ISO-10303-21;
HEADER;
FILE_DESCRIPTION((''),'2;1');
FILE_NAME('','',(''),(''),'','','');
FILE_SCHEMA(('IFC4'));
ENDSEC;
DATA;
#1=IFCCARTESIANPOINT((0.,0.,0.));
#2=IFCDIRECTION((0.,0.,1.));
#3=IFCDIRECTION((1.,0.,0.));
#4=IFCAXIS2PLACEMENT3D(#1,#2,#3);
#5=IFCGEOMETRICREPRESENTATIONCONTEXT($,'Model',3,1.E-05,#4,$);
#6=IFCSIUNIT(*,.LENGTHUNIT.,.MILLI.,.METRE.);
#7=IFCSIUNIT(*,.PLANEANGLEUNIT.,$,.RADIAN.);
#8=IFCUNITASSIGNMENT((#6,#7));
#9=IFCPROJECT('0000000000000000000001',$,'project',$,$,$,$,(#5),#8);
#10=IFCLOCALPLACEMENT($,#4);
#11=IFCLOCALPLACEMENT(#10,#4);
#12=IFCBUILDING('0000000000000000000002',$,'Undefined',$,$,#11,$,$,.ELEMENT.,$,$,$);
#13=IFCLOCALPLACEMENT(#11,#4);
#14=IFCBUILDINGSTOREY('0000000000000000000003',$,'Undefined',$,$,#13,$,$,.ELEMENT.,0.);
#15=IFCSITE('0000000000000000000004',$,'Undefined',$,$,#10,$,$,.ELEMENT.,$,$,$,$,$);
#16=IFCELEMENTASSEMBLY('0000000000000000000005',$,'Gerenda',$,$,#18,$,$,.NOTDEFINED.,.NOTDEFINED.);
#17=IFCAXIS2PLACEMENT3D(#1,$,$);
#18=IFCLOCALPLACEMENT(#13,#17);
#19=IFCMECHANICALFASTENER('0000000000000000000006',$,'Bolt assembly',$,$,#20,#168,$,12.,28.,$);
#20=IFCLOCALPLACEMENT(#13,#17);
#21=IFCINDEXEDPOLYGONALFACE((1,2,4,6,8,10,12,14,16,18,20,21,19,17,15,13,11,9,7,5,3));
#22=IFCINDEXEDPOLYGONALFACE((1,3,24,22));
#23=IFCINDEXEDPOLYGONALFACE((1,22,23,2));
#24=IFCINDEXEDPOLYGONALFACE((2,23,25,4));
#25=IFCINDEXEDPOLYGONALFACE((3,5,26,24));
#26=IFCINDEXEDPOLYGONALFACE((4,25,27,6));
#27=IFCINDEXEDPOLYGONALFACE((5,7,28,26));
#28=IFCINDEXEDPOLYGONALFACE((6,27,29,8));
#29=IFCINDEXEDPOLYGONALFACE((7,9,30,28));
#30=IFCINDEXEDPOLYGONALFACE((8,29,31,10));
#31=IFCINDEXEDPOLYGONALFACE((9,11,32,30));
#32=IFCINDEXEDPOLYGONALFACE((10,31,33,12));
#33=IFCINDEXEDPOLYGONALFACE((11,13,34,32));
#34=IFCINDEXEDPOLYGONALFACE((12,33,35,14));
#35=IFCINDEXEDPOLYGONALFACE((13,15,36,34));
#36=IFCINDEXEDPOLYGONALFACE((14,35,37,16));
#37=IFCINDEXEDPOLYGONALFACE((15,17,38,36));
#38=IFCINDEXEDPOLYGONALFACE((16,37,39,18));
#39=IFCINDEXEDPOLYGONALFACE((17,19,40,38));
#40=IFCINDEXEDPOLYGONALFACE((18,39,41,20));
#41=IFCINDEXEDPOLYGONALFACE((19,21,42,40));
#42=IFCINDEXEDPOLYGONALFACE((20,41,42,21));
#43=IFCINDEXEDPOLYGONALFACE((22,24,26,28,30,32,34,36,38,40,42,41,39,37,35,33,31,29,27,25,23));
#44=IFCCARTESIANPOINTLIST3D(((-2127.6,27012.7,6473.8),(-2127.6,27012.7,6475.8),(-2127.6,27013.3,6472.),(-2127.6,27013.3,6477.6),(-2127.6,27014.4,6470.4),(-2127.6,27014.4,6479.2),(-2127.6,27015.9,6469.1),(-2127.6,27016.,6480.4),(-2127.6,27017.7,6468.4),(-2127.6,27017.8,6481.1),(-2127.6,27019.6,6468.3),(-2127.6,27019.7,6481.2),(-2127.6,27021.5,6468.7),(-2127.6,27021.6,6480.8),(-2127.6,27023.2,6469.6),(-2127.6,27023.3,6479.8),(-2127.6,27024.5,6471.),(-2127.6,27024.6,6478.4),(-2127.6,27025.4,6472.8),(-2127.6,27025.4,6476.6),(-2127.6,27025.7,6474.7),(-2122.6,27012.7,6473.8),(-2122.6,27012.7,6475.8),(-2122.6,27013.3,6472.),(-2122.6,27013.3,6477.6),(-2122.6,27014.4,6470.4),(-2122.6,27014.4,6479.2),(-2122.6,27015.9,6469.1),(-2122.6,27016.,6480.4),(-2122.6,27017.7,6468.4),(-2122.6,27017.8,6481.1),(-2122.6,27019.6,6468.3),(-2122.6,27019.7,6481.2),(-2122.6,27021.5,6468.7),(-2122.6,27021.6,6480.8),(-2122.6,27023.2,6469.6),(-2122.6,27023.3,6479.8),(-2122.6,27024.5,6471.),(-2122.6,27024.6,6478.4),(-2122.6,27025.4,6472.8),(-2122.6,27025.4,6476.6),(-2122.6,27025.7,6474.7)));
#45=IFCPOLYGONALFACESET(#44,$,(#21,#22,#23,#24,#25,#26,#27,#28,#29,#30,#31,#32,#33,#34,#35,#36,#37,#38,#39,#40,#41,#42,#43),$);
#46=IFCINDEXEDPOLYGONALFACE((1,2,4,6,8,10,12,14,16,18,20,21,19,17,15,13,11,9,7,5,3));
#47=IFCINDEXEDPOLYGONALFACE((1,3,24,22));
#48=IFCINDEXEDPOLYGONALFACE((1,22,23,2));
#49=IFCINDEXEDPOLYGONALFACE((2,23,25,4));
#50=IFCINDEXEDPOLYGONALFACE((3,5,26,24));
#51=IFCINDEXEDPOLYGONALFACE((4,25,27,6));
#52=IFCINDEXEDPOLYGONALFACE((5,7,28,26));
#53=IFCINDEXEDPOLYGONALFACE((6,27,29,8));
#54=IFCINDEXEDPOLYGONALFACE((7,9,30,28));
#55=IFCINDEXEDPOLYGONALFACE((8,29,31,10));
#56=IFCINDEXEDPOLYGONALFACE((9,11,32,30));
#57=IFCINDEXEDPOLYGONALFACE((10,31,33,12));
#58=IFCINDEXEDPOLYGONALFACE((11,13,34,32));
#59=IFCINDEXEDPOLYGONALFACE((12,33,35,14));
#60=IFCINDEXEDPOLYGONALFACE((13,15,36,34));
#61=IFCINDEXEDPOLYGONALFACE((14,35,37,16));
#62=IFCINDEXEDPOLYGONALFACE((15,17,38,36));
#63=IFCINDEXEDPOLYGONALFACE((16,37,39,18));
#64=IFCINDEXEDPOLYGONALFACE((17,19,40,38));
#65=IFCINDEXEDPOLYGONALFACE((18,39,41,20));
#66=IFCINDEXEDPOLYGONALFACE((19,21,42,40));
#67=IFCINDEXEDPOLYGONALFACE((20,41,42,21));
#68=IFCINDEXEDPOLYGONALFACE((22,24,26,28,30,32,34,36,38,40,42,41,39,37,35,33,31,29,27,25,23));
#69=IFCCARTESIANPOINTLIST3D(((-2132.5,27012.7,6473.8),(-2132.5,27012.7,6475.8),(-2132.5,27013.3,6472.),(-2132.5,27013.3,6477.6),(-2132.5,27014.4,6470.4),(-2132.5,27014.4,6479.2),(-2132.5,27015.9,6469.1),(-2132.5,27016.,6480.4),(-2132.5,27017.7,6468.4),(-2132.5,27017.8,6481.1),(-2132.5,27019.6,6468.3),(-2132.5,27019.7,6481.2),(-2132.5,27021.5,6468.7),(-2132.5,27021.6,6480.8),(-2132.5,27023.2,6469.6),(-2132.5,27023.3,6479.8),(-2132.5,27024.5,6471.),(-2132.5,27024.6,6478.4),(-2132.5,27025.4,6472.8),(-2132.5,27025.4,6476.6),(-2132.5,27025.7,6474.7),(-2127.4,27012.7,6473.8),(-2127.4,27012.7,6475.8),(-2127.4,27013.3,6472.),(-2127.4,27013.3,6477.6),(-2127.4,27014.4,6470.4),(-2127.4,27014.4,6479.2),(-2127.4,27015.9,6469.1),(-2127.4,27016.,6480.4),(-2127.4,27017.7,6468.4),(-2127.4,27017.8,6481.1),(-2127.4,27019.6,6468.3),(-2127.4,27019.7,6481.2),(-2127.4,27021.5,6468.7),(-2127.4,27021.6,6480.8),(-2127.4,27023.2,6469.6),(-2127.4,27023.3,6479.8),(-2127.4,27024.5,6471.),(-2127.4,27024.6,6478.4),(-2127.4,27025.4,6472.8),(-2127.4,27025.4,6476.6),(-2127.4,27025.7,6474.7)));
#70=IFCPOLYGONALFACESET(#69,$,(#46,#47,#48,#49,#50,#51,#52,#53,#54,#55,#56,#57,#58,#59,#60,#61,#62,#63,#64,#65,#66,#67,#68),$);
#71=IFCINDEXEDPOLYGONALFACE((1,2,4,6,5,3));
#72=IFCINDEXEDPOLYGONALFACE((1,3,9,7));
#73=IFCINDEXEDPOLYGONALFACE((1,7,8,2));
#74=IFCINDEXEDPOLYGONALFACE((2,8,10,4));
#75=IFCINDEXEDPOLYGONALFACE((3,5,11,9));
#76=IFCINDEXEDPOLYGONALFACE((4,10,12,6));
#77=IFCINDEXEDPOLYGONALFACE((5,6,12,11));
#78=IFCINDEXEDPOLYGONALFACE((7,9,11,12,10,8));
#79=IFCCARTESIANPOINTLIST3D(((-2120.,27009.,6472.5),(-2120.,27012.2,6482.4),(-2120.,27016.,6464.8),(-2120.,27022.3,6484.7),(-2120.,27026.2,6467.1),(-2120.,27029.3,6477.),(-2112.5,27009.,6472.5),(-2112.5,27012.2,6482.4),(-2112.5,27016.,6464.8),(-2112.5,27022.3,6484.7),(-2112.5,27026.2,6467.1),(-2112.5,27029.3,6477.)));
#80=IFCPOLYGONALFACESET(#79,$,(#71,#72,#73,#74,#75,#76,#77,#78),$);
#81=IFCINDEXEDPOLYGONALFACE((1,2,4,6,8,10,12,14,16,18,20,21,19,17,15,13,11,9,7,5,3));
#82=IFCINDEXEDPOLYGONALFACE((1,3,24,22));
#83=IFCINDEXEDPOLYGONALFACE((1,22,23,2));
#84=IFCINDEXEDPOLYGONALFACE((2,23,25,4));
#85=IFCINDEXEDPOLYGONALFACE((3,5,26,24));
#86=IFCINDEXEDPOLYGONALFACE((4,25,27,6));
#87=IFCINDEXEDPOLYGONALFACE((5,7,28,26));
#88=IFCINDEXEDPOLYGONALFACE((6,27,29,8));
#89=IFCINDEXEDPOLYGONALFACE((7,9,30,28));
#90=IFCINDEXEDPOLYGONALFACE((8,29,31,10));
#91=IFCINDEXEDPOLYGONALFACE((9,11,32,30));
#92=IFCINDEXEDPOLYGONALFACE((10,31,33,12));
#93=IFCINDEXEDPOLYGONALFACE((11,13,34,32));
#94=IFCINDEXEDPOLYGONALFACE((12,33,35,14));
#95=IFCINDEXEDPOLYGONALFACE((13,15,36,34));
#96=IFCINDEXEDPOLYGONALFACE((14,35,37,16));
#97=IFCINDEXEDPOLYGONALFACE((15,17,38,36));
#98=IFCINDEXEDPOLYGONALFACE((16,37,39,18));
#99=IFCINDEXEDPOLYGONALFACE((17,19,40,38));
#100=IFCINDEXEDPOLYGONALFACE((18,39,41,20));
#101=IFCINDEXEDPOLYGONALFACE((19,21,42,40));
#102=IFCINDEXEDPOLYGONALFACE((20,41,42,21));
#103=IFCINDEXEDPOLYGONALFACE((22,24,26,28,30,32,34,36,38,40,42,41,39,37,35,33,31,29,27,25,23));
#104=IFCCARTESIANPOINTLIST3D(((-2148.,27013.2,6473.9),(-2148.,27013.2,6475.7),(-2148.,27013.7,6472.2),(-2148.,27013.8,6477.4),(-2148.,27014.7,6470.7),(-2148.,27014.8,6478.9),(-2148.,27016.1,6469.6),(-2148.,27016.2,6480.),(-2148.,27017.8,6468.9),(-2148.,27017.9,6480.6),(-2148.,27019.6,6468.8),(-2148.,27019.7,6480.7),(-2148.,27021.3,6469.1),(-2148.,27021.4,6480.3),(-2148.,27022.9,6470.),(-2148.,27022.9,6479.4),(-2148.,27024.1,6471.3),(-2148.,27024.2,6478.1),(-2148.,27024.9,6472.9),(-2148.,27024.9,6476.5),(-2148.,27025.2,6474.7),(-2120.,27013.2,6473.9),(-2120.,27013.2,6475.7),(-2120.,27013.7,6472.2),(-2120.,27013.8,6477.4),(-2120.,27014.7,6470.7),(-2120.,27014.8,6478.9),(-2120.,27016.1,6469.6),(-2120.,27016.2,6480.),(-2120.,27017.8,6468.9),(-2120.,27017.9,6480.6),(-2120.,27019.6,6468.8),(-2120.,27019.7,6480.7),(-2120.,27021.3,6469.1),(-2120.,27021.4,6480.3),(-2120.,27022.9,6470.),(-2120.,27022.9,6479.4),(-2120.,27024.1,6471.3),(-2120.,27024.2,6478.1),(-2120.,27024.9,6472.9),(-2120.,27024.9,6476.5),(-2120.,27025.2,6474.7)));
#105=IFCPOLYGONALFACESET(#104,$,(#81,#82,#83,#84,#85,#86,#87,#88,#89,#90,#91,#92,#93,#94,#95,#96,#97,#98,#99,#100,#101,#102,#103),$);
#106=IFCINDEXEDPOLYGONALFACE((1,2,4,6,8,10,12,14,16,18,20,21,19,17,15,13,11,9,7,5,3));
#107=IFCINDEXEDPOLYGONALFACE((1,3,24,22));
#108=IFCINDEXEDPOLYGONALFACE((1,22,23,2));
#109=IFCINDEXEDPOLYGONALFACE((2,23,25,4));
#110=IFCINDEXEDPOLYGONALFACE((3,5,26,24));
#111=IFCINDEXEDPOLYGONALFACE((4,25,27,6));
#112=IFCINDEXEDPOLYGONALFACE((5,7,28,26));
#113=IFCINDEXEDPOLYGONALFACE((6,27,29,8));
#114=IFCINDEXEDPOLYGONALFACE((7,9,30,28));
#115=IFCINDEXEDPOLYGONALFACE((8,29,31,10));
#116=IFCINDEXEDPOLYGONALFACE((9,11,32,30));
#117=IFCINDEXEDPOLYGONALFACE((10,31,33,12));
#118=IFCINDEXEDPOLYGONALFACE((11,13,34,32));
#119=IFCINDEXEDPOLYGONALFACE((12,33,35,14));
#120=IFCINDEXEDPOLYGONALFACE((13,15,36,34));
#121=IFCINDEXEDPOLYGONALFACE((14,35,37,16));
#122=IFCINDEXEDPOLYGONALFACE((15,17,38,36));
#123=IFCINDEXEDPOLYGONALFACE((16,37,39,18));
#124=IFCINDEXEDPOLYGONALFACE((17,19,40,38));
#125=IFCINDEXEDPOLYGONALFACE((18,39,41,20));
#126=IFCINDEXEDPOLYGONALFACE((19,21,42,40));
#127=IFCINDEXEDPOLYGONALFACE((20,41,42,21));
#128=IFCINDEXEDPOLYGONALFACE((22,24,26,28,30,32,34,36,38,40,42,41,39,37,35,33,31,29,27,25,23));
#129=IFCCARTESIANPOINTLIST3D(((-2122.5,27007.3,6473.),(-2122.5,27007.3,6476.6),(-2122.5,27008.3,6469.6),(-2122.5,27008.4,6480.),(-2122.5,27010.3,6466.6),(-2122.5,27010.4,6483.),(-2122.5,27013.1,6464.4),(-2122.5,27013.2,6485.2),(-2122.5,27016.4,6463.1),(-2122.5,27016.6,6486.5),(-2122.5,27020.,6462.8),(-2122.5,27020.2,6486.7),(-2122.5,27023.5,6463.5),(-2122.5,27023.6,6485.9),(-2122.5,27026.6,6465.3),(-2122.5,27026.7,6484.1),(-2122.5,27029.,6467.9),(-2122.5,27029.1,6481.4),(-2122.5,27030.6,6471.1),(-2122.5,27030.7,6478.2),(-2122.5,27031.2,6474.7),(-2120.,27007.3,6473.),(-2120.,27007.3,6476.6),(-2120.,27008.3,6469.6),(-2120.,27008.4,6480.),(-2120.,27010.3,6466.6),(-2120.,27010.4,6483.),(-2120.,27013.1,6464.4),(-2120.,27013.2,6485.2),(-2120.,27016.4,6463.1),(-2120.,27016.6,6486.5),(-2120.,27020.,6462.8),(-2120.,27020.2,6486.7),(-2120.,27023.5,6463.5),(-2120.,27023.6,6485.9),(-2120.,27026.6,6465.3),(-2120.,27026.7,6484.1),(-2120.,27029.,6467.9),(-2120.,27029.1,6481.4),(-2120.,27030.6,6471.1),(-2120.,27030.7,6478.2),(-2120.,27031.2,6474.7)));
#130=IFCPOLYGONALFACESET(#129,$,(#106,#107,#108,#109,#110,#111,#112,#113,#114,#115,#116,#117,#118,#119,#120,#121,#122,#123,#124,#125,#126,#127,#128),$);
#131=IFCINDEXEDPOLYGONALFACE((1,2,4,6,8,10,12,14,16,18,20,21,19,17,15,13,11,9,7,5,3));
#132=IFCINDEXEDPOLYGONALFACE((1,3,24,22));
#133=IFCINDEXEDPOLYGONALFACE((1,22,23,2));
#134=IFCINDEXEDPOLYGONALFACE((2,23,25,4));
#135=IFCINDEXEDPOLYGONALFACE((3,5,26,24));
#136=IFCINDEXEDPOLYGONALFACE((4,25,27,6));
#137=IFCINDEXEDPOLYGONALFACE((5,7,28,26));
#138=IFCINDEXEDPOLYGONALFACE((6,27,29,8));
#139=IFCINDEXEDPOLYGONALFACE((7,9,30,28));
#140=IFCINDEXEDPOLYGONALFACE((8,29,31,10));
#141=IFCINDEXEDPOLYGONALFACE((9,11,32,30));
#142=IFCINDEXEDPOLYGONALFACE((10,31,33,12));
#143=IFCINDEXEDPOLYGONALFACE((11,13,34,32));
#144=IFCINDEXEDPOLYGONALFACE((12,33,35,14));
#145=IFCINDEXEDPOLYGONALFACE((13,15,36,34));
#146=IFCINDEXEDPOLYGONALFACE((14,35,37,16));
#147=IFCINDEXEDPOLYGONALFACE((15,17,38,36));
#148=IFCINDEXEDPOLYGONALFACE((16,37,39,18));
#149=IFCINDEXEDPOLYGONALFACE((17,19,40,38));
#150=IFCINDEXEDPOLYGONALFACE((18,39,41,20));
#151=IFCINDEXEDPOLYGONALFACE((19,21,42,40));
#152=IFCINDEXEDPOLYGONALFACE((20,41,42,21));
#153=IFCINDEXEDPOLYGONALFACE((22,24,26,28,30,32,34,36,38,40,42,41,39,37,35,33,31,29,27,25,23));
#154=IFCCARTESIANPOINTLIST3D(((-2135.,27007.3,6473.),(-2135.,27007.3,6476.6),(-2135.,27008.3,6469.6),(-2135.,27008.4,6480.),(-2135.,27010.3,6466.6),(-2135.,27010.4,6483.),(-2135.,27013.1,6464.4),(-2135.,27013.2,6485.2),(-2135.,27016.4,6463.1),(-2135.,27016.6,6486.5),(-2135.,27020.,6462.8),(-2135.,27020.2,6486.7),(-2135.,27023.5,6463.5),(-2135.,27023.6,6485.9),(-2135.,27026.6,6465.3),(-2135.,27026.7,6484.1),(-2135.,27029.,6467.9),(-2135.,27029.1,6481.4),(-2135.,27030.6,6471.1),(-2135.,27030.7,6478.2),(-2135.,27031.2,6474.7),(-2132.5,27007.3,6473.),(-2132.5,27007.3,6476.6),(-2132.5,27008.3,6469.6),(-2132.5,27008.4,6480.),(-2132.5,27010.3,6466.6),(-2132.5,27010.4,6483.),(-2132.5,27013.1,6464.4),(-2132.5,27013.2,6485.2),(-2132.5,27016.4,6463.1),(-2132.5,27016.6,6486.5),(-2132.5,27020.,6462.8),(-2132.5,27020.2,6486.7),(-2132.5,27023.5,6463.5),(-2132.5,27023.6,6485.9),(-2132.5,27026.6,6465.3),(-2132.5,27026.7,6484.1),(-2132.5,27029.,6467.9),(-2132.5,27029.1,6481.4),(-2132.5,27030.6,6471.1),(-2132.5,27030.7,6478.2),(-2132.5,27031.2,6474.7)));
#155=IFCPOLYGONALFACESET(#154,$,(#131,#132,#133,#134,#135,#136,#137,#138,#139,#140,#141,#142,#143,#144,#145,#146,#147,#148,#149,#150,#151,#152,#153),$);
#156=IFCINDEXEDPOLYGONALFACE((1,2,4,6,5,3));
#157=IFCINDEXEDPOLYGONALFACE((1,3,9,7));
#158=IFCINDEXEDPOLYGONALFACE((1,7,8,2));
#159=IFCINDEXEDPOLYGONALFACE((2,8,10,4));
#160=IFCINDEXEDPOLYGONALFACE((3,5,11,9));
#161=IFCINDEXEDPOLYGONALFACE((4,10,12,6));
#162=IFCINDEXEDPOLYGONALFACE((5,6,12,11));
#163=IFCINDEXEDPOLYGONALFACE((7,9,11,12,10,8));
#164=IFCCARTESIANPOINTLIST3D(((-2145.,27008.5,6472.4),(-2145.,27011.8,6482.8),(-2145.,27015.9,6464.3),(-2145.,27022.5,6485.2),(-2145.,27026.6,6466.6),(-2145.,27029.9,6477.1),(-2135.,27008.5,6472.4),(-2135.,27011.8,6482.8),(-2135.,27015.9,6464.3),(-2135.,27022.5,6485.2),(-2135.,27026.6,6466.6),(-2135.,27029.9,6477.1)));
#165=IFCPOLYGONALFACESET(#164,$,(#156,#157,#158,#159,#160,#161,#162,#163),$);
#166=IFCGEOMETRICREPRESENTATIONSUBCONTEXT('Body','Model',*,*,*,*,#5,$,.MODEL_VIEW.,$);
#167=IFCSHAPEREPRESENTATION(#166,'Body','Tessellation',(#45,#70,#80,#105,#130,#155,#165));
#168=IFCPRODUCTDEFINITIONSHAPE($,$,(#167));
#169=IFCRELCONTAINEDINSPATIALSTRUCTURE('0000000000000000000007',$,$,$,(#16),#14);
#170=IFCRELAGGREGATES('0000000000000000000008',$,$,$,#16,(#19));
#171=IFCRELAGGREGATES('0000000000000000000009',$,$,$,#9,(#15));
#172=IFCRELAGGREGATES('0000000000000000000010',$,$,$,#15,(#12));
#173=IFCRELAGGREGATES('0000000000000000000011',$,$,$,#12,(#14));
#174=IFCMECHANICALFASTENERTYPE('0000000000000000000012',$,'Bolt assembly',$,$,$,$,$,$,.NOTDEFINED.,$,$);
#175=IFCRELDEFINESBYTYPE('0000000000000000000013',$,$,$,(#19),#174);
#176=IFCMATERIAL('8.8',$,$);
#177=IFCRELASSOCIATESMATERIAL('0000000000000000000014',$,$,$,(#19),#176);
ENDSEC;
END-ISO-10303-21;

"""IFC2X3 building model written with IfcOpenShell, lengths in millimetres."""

from ifc_helpers import new_model, si_unit, frame, origin_with_axes, origin_2d_with_axis, place, context, subcontext, project, spatial, polyline, circle, outline, extrude, source, transform, mapped, material, type_object, element, aggregate, save


model = new_model("IFC2X3")

# Units and contexts
model_context = context("Model", 3, precision=1e-05, world=origin_with_axes())
body_context = subcontext(model_context, "Body", "Model", "MODEL_VIEW")
ifc_project = project(units=[si_unit("LENGTHUNIT", "METRE", prefix="MILLI"), si_unit("PLANEANGLEUNIT", "RADIAN")], contexts=[model_context])

# Site, building, storey
site_placement = place(None, origin_with_axes())
site = spatial("IfcSite", under=ifc_project, at=site_placement, Name="Undefined", CompositionType="ELEMENT")
building_placement = place(site_placement, origin_with_axes())
building = spatial("IfcBuilding", under=site, at=building_placement, Name="Undefined", CompositionType="ELEMENT")
storey_placement = place(building_placement, origin_with_axes())
storey = spatial("IfcBuildingStorey", under=building, at=storey_placement, Name="Undefined", CompositionType="ELEMENT", Elevation=0.0)

# Element assembly
assembly_1_placement = place(storey_placement, origin_with_axes())
assembly_1 = element("IfcElementAssembly", 1, at=assembly_1_placement, inside=storey, Name="Gerenda", AssemblyPlace="NOTDEFINED", PredefinedType="NOTDEFINED")

# Mechanical fastener
ifc_material_1 = material(Name="8.8")
mechanical_fastener_type = type_object("IfcMechanicalFastenerType", Name="Bolt assembly")
shared_shape_1 = source(origin_with_axes(), body_context, "Body", "SweptSolid", [
    extrude(circle(Radius=6.5, at=origin_2d_with_axis()), frame((0.0, -7.4, 0.0), z_axis=(0.0, 1.0, 0.0), x_axis=(1.0, 0.0, 0.0)), (0.0, 0.0, 1.0), 5.0),
    extrude(circle(Radius=6.5, at=origin_2d_with_axis()), frame((0.0, -2.6, 0.0), z_axis=(0.0, 1.0, 0.0), x_axis=(1.0, 0.0, 0.0)), (0.0, 0.0, 1.0), 5.1),
    extrude(outline(polyline([(9.0, -5.2), (9.0, 5.2), (0.0, 10.4), (-9.0, 5.2), (-9.0, -5.2), (0.0, -10.4), (9.0, -5.2)])), frame((0.0, -17.5, 0.0), z_axis=(0.0, 1.0, 0.0), x_axis=(1.0, 0.0, 0.0)), (0.0, 0.0, 1.0), 7.5),
    extrude(circle(Radius=6.0, at=origin_2d_with_axis()), frame((0.0, -10.0, 0.0), z_axis=(0.0, 1.0, 0.0), x_axis=(1.0, 0.0, 0.0)), (0.0, 0.0, 1.0), 28.0),
    extrude(circle(Radius=12.0, at=origin_2d_with_axis()), frame((0.0, -10.0, 0.0), z_axis=(0.0, 1.0, 0.0), x_axis=(1.0, 0.0, 0.0)), (0.0, 0.0, 1.0), 2.5),
    extrude(circle(Radius=12.0, at=origin_2d_with_axis()), frame((0.0, 2.5, 0.0), z_axis=(0.0, 1.0, 0.0), x_axis=(1.0, 0.0, 0.0)), (0.0, 0.0, 1.0), 2.5),
    extrude(outline(polyline([(9.5, -5.5), (9.5, 5.5), (0.0, 11.0), (-9.5, 5.5), (-9.5, -5.5), (0.0, -11.0), (9.5, -5.5)])), frame((0.0, 5.0, 0.0), z_axis=(0.0, 1.0, 0.0), x_axis=(1.0, 0.0, 0.0)), (0.0, 0.0, 1.0), 10.0),
])
mechanical_fastener_1_placement = place(assembly_1_placement, frame((-2130.0, 27019.2, 6474.7), z_axis=(0.0, 0.674627, -0.738159), x_axis=(-0.000003, -0.738159, -0.674627)))
mechanical_fastener_1 = element("IfcMechanicalFastener", 2, at=mechanical_fastener_1_placement, type_object=mechanical_fastener_type, material=ifc_material_1, Name="Bolt assembly", NominalDiameter=12.0, NominalLength=28.0, context=body_context, shape_type="MappedRepresentation", body=[
    mapped(shared_shape_1, transform((0.0, 0.0, 0.0))),
])
aggregate(assembly_1, [mechanical_fastener_1])

save(model, "model.ifc")
